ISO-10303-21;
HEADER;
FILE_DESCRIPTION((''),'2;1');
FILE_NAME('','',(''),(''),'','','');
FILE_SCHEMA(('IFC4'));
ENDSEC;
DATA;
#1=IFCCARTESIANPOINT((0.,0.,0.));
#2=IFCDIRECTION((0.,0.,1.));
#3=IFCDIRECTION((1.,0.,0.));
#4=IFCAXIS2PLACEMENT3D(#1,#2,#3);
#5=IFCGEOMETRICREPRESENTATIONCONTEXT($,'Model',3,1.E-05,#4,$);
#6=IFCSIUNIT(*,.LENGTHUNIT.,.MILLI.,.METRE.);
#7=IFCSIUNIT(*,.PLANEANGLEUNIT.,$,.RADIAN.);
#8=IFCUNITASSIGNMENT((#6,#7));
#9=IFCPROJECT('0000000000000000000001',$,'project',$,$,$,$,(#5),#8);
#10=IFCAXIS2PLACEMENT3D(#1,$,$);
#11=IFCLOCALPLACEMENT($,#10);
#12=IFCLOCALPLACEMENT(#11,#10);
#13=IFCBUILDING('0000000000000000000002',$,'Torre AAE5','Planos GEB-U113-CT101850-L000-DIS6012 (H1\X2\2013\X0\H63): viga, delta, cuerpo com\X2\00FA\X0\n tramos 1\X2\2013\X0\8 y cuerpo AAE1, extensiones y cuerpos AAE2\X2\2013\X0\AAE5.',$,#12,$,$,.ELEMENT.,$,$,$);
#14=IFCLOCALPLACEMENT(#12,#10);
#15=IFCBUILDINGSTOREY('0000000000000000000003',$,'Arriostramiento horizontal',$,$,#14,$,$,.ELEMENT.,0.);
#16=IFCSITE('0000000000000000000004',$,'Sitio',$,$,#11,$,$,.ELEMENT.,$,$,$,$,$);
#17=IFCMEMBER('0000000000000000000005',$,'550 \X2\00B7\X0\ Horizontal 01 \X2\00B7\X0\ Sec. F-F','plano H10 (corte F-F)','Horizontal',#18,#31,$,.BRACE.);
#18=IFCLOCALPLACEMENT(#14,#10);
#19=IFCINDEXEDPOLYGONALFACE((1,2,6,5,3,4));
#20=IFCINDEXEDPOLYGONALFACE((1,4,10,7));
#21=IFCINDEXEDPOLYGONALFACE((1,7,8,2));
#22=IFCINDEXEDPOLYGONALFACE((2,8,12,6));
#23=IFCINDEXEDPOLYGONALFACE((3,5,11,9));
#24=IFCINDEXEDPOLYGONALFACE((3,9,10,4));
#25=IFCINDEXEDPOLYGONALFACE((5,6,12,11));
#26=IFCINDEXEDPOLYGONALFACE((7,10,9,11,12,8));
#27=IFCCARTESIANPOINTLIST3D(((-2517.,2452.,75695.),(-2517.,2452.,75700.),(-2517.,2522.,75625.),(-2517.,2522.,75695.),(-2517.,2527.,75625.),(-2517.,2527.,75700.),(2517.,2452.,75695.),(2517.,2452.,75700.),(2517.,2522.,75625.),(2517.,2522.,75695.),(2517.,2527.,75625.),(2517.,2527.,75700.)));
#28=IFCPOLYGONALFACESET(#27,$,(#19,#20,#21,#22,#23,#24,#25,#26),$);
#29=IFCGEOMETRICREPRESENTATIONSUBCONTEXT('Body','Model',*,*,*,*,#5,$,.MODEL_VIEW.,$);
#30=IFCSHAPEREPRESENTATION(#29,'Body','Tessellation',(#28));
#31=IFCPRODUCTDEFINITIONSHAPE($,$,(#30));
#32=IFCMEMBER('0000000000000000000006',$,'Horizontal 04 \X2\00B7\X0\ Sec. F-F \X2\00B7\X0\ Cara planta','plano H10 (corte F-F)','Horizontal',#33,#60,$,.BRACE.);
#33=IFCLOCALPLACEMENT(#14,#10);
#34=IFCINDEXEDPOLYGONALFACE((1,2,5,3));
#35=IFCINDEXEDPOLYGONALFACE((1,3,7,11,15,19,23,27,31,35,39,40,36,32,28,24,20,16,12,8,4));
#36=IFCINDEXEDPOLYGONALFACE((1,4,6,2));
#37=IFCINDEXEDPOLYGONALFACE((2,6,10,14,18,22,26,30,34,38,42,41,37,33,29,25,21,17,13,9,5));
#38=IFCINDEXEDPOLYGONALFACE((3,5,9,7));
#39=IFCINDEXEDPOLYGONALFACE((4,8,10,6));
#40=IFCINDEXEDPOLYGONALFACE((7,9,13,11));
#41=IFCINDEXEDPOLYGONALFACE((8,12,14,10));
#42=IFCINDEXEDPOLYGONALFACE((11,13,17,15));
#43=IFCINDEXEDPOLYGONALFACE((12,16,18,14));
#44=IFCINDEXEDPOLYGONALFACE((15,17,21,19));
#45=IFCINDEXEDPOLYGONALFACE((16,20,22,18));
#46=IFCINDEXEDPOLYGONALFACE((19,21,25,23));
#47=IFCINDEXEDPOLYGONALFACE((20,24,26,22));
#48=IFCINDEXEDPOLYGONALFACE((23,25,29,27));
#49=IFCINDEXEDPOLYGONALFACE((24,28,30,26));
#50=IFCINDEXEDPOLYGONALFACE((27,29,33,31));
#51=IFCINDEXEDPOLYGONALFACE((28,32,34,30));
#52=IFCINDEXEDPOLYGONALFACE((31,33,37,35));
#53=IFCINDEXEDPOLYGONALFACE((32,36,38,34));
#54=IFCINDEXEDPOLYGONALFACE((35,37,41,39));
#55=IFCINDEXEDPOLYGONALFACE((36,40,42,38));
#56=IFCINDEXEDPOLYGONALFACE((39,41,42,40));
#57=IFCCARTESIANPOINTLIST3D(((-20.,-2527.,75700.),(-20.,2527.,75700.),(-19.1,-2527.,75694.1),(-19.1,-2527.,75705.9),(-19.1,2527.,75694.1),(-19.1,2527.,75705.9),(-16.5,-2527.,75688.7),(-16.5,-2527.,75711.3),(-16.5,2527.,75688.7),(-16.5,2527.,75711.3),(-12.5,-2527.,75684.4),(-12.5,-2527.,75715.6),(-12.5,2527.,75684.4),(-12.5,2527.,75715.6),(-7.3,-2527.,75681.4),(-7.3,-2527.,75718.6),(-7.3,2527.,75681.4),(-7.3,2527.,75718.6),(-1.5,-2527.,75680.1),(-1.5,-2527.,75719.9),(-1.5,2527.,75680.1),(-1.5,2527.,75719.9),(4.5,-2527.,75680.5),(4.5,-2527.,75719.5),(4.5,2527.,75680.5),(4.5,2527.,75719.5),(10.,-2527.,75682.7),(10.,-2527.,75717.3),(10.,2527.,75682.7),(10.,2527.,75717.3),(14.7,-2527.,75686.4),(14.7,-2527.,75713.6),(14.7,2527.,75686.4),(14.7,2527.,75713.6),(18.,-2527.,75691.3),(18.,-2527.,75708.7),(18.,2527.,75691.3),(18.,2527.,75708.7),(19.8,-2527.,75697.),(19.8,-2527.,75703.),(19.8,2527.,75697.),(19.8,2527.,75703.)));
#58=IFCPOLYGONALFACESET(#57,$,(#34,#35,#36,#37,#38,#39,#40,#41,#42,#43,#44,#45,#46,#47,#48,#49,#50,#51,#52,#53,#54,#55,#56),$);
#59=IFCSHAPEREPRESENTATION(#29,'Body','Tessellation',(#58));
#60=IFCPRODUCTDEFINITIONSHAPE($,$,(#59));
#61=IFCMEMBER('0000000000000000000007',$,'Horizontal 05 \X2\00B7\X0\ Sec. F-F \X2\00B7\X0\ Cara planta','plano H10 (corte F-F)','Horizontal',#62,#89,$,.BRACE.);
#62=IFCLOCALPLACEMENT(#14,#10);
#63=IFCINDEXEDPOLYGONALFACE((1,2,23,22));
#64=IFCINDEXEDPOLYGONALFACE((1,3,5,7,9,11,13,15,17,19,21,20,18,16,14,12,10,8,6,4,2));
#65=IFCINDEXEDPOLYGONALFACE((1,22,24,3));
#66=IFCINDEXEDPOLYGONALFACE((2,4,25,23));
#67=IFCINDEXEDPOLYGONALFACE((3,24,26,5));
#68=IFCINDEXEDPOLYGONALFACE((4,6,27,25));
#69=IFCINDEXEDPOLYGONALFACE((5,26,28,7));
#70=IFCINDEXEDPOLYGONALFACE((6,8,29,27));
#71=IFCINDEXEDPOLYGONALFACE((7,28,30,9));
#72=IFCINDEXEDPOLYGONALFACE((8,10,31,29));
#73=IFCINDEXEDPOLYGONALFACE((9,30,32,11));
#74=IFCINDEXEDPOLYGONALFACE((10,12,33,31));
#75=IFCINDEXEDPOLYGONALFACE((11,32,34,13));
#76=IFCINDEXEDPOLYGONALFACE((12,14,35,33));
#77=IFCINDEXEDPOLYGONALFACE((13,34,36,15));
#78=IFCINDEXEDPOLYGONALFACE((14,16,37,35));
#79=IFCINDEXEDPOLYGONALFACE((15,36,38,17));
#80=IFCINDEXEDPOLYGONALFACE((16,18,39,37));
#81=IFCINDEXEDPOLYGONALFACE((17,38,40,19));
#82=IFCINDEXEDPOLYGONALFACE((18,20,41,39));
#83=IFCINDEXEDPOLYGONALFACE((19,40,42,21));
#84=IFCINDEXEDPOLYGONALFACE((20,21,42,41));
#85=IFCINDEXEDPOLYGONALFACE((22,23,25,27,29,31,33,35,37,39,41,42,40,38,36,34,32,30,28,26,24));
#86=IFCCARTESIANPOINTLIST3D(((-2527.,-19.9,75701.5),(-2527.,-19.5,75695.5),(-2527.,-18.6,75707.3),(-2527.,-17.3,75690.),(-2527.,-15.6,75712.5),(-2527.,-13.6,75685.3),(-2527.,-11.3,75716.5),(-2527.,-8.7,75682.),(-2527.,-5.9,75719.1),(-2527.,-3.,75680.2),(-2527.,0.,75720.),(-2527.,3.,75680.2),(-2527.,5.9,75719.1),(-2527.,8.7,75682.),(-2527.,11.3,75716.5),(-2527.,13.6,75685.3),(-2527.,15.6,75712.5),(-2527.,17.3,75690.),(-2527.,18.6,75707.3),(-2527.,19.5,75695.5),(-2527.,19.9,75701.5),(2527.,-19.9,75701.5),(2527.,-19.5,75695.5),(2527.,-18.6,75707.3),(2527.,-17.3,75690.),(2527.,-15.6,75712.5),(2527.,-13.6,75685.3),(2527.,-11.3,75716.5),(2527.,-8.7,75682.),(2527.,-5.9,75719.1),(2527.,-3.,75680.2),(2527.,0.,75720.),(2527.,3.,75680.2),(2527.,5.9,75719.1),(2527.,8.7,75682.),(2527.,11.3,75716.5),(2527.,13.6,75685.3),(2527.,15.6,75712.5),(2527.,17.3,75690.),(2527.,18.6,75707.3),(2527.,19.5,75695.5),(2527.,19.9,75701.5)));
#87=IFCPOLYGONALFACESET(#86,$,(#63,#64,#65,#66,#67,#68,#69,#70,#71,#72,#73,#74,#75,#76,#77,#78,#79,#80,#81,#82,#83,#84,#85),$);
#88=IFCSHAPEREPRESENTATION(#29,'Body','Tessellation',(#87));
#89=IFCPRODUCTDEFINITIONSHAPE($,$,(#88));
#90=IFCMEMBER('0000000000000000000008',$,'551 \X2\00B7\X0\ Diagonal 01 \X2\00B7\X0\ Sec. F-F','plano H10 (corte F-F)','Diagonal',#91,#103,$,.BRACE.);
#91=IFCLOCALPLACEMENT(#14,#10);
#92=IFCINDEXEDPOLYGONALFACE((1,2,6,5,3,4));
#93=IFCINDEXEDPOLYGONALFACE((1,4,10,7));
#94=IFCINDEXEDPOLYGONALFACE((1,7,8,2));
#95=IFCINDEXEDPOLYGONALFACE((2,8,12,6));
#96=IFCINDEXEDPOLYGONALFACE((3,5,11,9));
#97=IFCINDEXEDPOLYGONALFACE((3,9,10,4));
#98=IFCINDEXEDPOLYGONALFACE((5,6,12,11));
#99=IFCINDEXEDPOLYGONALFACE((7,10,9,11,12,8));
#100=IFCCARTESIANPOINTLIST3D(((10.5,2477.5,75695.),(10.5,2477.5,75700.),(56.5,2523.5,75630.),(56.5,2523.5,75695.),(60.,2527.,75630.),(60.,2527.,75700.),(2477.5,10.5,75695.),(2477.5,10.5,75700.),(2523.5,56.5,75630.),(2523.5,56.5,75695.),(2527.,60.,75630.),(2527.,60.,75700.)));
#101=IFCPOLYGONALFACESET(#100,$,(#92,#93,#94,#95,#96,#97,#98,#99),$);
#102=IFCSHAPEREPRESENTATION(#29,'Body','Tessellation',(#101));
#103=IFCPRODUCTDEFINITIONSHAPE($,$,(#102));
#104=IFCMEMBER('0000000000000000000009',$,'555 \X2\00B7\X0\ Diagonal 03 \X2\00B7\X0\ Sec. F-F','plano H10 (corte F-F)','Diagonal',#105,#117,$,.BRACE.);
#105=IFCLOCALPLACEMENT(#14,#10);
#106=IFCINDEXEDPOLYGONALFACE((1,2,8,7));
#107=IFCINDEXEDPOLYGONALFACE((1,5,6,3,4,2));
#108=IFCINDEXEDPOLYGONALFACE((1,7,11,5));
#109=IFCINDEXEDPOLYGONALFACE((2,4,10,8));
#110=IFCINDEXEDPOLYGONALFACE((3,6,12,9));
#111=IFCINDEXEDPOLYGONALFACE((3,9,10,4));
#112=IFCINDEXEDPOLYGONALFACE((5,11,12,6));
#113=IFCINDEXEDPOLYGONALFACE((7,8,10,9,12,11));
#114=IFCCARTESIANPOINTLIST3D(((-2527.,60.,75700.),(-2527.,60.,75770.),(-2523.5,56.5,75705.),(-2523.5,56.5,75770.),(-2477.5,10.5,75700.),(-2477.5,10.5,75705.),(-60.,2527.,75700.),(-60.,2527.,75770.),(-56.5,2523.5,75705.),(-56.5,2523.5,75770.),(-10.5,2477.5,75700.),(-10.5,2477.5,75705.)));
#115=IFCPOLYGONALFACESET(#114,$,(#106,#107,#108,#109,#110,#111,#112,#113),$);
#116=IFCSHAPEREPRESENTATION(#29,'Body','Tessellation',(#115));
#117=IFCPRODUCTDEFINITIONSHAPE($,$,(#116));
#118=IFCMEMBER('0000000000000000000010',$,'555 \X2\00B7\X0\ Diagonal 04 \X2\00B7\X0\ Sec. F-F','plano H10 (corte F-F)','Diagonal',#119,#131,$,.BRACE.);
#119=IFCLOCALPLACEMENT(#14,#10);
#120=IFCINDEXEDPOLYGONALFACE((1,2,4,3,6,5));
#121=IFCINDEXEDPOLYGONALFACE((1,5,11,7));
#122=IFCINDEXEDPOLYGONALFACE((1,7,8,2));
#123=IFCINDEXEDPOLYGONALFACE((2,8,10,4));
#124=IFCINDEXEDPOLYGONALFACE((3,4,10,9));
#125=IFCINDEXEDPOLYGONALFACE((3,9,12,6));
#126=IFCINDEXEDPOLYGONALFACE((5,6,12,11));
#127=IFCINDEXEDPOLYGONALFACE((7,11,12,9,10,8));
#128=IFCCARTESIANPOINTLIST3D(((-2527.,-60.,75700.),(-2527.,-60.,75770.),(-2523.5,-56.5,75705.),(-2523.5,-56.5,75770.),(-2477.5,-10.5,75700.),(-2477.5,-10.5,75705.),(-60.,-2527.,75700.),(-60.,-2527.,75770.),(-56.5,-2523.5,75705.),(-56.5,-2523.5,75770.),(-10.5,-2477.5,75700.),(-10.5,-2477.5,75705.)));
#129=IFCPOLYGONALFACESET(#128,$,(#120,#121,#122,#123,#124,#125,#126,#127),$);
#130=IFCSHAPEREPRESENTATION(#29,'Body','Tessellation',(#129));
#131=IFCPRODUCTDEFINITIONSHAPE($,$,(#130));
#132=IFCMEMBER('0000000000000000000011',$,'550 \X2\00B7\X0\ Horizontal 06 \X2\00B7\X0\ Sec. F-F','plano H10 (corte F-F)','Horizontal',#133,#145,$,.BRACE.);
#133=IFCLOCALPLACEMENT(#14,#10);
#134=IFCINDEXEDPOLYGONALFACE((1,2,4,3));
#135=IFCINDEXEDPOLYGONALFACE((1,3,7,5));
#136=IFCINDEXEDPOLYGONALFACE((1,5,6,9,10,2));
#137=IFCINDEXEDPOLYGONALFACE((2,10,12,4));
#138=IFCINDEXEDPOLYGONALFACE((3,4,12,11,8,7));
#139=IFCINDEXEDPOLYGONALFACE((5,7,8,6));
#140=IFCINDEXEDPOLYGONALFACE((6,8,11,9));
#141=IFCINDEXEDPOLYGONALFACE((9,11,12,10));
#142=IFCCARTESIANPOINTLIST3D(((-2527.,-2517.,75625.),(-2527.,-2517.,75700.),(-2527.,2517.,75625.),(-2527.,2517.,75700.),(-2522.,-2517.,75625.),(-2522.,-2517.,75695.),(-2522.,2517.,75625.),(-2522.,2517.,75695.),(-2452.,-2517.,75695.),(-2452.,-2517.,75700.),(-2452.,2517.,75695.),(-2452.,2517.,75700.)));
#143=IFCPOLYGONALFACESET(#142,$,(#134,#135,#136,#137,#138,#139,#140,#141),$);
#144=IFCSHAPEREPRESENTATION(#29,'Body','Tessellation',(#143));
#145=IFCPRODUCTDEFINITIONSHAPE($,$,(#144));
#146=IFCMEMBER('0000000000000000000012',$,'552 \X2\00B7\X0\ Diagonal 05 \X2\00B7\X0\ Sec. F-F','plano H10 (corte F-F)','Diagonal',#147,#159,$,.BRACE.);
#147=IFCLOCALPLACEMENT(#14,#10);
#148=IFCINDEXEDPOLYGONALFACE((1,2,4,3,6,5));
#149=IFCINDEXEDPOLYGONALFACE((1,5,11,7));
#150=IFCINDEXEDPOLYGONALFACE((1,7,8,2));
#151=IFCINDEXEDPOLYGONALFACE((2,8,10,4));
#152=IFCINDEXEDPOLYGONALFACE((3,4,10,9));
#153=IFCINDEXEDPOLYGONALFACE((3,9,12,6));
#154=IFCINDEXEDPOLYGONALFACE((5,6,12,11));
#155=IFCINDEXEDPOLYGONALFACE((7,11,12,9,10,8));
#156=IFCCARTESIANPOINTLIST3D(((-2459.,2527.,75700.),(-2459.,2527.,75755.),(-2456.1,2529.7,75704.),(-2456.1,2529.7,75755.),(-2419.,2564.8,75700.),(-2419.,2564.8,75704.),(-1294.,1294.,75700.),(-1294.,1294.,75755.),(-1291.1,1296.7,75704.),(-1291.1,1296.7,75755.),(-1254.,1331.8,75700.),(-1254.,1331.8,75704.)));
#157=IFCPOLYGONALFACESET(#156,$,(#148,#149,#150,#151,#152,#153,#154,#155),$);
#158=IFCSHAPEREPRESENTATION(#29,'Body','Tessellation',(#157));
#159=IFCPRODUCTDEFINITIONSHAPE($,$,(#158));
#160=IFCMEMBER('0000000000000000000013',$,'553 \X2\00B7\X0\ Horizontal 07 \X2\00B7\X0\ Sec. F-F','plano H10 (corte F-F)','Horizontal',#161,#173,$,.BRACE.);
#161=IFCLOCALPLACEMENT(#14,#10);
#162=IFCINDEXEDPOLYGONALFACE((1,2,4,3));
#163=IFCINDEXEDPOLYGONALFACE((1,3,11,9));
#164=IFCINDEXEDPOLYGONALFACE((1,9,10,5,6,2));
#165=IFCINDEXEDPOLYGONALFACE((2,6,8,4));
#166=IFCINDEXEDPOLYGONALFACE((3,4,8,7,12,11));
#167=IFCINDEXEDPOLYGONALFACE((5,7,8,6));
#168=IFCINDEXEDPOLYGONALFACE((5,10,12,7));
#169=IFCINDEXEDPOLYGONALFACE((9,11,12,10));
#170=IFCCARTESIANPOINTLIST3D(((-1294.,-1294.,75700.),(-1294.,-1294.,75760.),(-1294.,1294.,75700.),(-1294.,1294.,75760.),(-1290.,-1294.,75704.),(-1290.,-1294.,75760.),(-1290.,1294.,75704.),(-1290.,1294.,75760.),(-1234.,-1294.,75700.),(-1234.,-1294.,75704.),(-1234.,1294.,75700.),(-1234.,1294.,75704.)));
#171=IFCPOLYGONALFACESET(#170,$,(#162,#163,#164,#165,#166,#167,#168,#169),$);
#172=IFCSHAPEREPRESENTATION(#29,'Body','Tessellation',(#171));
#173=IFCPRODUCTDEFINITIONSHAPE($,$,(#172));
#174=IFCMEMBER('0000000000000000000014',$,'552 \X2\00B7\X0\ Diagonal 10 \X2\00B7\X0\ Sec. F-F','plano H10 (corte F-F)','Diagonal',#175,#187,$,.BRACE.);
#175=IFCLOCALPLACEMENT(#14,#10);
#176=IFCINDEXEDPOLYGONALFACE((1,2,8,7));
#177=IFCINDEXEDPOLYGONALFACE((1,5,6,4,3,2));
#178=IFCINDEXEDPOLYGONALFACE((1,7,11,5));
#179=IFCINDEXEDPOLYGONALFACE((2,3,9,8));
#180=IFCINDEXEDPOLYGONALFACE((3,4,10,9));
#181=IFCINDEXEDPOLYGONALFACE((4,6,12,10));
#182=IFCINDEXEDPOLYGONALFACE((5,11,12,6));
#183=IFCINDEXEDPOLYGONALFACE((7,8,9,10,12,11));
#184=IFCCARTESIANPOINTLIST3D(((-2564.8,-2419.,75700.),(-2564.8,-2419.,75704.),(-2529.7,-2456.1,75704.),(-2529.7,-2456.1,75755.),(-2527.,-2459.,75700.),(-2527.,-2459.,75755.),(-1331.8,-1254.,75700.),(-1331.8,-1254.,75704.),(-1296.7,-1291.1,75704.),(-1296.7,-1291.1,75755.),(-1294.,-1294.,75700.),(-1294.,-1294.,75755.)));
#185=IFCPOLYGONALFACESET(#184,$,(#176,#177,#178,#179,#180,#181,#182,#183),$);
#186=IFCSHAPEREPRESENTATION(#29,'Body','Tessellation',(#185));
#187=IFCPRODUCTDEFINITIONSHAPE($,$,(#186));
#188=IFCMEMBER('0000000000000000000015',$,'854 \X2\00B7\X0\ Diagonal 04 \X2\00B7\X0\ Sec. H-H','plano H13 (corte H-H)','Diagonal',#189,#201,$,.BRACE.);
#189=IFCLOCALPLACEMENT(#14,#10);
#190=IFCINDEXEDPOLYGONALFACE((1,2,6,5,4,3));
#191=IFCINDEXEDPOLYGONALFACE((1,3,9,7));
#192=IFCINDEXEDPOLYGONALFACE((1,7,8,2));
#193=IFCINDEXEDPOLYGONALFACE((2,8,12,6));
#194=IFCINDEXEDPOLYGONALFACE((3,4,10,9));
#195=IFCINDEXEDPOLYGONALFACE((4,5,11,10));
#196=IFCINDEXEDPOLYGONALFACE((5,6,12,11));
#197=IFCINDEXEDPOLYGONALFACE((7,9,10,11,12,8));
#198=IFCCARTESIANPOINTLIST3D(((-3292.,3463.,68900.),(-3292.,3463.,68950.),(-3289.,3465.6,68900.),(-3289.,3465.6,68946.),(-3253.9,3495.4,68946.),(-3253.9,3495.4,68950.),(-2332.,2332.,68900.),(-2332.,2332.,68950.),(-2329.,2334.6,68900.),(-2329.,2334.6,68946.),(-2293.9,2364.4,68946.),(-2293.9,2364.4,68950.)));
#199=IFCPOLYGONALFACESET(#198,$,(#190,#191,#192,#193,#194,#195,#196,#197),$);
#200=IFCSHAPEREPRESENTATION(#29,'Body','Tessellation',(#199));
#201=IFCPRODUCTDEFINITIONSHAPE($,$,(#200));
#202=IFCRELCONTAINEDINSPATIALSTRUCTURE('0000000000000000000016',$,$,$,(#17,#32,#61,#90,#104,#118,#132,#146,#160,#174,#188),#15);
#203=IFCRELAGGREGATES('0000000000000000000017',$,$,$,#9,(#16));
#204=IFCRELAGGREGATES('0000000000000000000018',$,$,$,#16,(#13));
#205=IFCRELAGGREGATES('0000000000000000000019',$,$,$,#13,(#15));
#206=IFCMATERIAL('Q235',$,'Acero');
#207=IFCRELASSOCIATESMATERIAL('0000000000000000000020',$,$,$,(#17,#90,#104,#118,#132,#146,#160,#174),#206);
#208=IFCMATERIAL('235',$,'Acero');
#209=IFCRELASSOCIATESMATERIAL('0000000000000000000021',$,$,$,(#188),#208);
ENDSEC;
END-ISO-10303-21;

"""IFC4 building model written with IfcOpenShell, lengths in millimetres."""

from ifc_helpers import new_model, si_unit, frame, frame_2d, origin, origin_with_axes, place, context, subcontext, project, spatial, circle, l_section, extrude, material, element, save


model = new_model("IFC4")

# Units and contexts
model_context = context("Model", 3, precision=1e-05, world=origin_with_axes())
body_context = subcontext(model_context, "Body", "Model", "MODEL_VIEW")
ifc_project = project(units=[si_unit("LENGTHUNIT", "METRE", prefix="MILLI"), si_unit("PLANEANGLEUNIT", "RADIAN")], contexts=[model_context])

# Site, building, storey
site_placement = place(None, origin())
site = spatial("IfcSite", under=ifc_project, at=site_placement, Name="Sitio", CompositionType="ELEMENT")
building_placement = place(site_placement, origin())
building = spatial("IfcBuilding", under=site, at=building_placement, Name="Torre AAE5", Description="Planos GEB-U113-CT101850-L000-DIS6012 (H1–H63): viga, delta, cuerpo común tramos 1–8 y cuerpo AAE1, extensiones y cuerpos AAE2–AAE5.", CompositionType="ELEMENT")
storey_placement = place(building_placement, origin())
storey = spatial("IfcBuildingStorey", under=building, at=storey_placement, Name="Arriostramiento horizontal", CompositionType="ELEMENT", Elevation=0.0)

# Members
ifc_material_1 = material(Name="Q235", Category="Acero")
member_1_placement = place(storey_placement, frame((-2517.0, 2527.0, 75700.0), z_axis=(1.0, 0.0, 0.0), x_axis=(0.0, -1.0, 0.0)))
element("IfcMember", 1, at=member_1_placement, inside=storey, material=ifc_material_1, Name="550 · Horizontal 01 · Sec. F-F", Description="plano H10 (corte F-F)", ObjectType="Horizontal", PredefinedType="BRACE", context=body_context, shape_type="SweptSolid", body=[
    extrude(l_section(Depth=75.0, Width=75.0, Thickness=5.0, at=frame_2d((37.5, 37.5))), None, (0.0, 0.0, 1.0), 5034.0),
])
for number, where, z_axis, x_axis, name in (
    (2, (0.0, -2527.0, 75700.0), (0.0, 1.0, 0.0), (-1.0, 0.0, 0.0), "Horizontal 04 · Sec. F-F · Cara planta"),
    (3, (-2527.0, 0.0, 75700.0), (1.0, 0.0, 0.0), (0.0, 0.0, 1.0), "Horizontal 05 · Sec. F-F · Cara planta"),
):
    element("IfcMember", number, at=place(storey_placement, frame(where, z_axis=z_axis, x_axis=x_axis)), inside=storey, Name=name, Description="plano H10 (corte F-F)", ObjectType="Horizontal", PredefinedType="BRACE", context=body_context, shape_type="SweptSolid", body=[
        extrude(circle(Radius=20.0), None, (0.0, 0.0, 1.0), 5054.0),
    ])
for number, where, z_axis, x_axis, name in (
    (4, (60.0, 2527.0, 75700.0), (0.707107, -0.707107, 0.0), (-0.707107, -0.707107, 0.0), "551 · Diagonal 01 · Sec. F-F"),
    (5, (-60.0, 2527.0, 75700.0), (-0.707107, -0.707107, 0.0), (0.707107, -0.707107, 0.0), "555 · Diagonal 03 · Sec. F-F"),
    (6, (-2527.0, -60.0, 75700.0), (0.707107, -0.707107, 0.0), (0.707107, 0.707107, 0.0), "555 · Diagonal 04 · Sec. F-F"),
):
    element("IfcMember", number, at=place(storey_placement, frame(where, z_axis=z_axis, x_axis=x_axis)), inside=storey, material=ifc_material_1, Name=name, Description="plano H10 (corte F-F)", ObjectType="Diagonal", PredefinedType="BRACE", context=body_context, shape_type="SweptSolid", body=[
        extrude(l_section(Depth=70.0, Width=70.0, Thickness=5.0, at=frame_2d((35.0, 35.0))), None, (0.0, 0.0, 1.0), 3488.9),
    ])
member_2_placement = place(storey_placement, frame((-2527.0, -2517.0, 75700.0), z_axis=(0.0, 1.0, 0.0), x_axis=(1.0, 0.0, 0.0)))
element("IfcMember", 7, at=member_2_placement, inside=storey, material=ifc_material_1, Name="550 · Horizontal 06 · Sec. F-F", Description="plano H10 (corte F-F)", ObjectType="Horizontal", PredefinedType="BRACE", context=body_context, shape_type="SweptSolid", body=[
    extrude(l_section(Depth=75.0, Width=75.0, Thickness=5.0, at=frame_2d((37.5, 37.5))), None, (0.0, 0.0, 1.0), 5034.0),
])
member_3_placement = place(storey_placement, frame((-2459.0, 2527.0, 75700.0), z_axis=(0.686779, -0.726866, 0.0), x_axis=(0.726866, 0.686779, 0.0)))
element("IfcMember", 8, at=member_3_placement, inside=storey, material=ifc_material_1, Name="552 · Diagonal 05 · Sec. F-F", Description="plano H10 (corte F-F)", ObjectType="Diagonal", PredefinedType="BRACE", context=body_context, shape_type="SweptSolid", body=[
    extrude(l_section(Depth=55.0, Width=55.0, Thickness=4.0, at=frame_2d((27.5, 27.5))), None, (0.0, 0.0, 1.0), 1696.3),
])
member_4_placement = place(storey_placement, frame((-1294.0, 1294.0, 75700.0), z_axis=(0.0, -1.0, 0.0), x_axis=(1.0, 0.0, 0.0)))
element("IfcMember", 9, at=member_4_placement, inside=storey, material=ifc_material_1, Name="553 · Horizontal 07 · Sec. F-F", Description="plano H10 (corte F-F)", ObjectType="Horizontal", PredefinedType="BRACE", context=body_context, shape_type="SweptSolid", body=[
    extrude(l_section(Depth=60.0, Width=60.0, Thickness=4.0, at=frame_2d((30.0, 30.0))), None, (0.0, 0.0, 1.0), 2588.0),
])
member_5_placement = place(storey_placement, frame((-2527.0, -2459.0, 75700.0), z_axis=(0.726866, 0.686779, 0.0), x_axis=(-0.686779, 0.726866, 0.0)))
element("IfcMember", 10, at=member_5_placement, inside=storey, material=ifc_material_1, Name="552 · Diagonal 10 · Sec. F-F", Description="plano H10 (corte F-F)", ObjectType="Diagonal", PredefinedType="BRACE", context=body_context, shape_type="SweptSolid", body=[
    extrude(l_section(Depth=55.0, Width=55.0, Thickness=4.0, at=frame_2d((27.5, 27.5))), None, (0.0, 0.0, 1.0), 1696.3),
])
ifc_material_2 = material(Name="235", Category="Acero")
member_6_placement = place(storey_placement, frame((-2332.0, 2332.0, 68950.0), z_axis=(-0.64712, 0.762388, 0.0), x_axis=(0.762388, 0.64712, 0.0)))
element("IfcMember", 11, at=member_6_placement, inside=storey, material=ifc_material_2, Name="854 · Diagonal 04 · Sec. H-H", Description="plano H13 (corte H-H)", ObjectType="Diagonal", PredefinedType="BRACE", context=body_context, shape_type="SweptSolid", body=[
    extrude(l_section(Depth=50.0, Width=50.0, Thickness=4.0, at=frame_2d((25.0, 25.0))), None, (0.0, 0.0, 1.0), 1483.5),
])

save(model, "model.ifc")
